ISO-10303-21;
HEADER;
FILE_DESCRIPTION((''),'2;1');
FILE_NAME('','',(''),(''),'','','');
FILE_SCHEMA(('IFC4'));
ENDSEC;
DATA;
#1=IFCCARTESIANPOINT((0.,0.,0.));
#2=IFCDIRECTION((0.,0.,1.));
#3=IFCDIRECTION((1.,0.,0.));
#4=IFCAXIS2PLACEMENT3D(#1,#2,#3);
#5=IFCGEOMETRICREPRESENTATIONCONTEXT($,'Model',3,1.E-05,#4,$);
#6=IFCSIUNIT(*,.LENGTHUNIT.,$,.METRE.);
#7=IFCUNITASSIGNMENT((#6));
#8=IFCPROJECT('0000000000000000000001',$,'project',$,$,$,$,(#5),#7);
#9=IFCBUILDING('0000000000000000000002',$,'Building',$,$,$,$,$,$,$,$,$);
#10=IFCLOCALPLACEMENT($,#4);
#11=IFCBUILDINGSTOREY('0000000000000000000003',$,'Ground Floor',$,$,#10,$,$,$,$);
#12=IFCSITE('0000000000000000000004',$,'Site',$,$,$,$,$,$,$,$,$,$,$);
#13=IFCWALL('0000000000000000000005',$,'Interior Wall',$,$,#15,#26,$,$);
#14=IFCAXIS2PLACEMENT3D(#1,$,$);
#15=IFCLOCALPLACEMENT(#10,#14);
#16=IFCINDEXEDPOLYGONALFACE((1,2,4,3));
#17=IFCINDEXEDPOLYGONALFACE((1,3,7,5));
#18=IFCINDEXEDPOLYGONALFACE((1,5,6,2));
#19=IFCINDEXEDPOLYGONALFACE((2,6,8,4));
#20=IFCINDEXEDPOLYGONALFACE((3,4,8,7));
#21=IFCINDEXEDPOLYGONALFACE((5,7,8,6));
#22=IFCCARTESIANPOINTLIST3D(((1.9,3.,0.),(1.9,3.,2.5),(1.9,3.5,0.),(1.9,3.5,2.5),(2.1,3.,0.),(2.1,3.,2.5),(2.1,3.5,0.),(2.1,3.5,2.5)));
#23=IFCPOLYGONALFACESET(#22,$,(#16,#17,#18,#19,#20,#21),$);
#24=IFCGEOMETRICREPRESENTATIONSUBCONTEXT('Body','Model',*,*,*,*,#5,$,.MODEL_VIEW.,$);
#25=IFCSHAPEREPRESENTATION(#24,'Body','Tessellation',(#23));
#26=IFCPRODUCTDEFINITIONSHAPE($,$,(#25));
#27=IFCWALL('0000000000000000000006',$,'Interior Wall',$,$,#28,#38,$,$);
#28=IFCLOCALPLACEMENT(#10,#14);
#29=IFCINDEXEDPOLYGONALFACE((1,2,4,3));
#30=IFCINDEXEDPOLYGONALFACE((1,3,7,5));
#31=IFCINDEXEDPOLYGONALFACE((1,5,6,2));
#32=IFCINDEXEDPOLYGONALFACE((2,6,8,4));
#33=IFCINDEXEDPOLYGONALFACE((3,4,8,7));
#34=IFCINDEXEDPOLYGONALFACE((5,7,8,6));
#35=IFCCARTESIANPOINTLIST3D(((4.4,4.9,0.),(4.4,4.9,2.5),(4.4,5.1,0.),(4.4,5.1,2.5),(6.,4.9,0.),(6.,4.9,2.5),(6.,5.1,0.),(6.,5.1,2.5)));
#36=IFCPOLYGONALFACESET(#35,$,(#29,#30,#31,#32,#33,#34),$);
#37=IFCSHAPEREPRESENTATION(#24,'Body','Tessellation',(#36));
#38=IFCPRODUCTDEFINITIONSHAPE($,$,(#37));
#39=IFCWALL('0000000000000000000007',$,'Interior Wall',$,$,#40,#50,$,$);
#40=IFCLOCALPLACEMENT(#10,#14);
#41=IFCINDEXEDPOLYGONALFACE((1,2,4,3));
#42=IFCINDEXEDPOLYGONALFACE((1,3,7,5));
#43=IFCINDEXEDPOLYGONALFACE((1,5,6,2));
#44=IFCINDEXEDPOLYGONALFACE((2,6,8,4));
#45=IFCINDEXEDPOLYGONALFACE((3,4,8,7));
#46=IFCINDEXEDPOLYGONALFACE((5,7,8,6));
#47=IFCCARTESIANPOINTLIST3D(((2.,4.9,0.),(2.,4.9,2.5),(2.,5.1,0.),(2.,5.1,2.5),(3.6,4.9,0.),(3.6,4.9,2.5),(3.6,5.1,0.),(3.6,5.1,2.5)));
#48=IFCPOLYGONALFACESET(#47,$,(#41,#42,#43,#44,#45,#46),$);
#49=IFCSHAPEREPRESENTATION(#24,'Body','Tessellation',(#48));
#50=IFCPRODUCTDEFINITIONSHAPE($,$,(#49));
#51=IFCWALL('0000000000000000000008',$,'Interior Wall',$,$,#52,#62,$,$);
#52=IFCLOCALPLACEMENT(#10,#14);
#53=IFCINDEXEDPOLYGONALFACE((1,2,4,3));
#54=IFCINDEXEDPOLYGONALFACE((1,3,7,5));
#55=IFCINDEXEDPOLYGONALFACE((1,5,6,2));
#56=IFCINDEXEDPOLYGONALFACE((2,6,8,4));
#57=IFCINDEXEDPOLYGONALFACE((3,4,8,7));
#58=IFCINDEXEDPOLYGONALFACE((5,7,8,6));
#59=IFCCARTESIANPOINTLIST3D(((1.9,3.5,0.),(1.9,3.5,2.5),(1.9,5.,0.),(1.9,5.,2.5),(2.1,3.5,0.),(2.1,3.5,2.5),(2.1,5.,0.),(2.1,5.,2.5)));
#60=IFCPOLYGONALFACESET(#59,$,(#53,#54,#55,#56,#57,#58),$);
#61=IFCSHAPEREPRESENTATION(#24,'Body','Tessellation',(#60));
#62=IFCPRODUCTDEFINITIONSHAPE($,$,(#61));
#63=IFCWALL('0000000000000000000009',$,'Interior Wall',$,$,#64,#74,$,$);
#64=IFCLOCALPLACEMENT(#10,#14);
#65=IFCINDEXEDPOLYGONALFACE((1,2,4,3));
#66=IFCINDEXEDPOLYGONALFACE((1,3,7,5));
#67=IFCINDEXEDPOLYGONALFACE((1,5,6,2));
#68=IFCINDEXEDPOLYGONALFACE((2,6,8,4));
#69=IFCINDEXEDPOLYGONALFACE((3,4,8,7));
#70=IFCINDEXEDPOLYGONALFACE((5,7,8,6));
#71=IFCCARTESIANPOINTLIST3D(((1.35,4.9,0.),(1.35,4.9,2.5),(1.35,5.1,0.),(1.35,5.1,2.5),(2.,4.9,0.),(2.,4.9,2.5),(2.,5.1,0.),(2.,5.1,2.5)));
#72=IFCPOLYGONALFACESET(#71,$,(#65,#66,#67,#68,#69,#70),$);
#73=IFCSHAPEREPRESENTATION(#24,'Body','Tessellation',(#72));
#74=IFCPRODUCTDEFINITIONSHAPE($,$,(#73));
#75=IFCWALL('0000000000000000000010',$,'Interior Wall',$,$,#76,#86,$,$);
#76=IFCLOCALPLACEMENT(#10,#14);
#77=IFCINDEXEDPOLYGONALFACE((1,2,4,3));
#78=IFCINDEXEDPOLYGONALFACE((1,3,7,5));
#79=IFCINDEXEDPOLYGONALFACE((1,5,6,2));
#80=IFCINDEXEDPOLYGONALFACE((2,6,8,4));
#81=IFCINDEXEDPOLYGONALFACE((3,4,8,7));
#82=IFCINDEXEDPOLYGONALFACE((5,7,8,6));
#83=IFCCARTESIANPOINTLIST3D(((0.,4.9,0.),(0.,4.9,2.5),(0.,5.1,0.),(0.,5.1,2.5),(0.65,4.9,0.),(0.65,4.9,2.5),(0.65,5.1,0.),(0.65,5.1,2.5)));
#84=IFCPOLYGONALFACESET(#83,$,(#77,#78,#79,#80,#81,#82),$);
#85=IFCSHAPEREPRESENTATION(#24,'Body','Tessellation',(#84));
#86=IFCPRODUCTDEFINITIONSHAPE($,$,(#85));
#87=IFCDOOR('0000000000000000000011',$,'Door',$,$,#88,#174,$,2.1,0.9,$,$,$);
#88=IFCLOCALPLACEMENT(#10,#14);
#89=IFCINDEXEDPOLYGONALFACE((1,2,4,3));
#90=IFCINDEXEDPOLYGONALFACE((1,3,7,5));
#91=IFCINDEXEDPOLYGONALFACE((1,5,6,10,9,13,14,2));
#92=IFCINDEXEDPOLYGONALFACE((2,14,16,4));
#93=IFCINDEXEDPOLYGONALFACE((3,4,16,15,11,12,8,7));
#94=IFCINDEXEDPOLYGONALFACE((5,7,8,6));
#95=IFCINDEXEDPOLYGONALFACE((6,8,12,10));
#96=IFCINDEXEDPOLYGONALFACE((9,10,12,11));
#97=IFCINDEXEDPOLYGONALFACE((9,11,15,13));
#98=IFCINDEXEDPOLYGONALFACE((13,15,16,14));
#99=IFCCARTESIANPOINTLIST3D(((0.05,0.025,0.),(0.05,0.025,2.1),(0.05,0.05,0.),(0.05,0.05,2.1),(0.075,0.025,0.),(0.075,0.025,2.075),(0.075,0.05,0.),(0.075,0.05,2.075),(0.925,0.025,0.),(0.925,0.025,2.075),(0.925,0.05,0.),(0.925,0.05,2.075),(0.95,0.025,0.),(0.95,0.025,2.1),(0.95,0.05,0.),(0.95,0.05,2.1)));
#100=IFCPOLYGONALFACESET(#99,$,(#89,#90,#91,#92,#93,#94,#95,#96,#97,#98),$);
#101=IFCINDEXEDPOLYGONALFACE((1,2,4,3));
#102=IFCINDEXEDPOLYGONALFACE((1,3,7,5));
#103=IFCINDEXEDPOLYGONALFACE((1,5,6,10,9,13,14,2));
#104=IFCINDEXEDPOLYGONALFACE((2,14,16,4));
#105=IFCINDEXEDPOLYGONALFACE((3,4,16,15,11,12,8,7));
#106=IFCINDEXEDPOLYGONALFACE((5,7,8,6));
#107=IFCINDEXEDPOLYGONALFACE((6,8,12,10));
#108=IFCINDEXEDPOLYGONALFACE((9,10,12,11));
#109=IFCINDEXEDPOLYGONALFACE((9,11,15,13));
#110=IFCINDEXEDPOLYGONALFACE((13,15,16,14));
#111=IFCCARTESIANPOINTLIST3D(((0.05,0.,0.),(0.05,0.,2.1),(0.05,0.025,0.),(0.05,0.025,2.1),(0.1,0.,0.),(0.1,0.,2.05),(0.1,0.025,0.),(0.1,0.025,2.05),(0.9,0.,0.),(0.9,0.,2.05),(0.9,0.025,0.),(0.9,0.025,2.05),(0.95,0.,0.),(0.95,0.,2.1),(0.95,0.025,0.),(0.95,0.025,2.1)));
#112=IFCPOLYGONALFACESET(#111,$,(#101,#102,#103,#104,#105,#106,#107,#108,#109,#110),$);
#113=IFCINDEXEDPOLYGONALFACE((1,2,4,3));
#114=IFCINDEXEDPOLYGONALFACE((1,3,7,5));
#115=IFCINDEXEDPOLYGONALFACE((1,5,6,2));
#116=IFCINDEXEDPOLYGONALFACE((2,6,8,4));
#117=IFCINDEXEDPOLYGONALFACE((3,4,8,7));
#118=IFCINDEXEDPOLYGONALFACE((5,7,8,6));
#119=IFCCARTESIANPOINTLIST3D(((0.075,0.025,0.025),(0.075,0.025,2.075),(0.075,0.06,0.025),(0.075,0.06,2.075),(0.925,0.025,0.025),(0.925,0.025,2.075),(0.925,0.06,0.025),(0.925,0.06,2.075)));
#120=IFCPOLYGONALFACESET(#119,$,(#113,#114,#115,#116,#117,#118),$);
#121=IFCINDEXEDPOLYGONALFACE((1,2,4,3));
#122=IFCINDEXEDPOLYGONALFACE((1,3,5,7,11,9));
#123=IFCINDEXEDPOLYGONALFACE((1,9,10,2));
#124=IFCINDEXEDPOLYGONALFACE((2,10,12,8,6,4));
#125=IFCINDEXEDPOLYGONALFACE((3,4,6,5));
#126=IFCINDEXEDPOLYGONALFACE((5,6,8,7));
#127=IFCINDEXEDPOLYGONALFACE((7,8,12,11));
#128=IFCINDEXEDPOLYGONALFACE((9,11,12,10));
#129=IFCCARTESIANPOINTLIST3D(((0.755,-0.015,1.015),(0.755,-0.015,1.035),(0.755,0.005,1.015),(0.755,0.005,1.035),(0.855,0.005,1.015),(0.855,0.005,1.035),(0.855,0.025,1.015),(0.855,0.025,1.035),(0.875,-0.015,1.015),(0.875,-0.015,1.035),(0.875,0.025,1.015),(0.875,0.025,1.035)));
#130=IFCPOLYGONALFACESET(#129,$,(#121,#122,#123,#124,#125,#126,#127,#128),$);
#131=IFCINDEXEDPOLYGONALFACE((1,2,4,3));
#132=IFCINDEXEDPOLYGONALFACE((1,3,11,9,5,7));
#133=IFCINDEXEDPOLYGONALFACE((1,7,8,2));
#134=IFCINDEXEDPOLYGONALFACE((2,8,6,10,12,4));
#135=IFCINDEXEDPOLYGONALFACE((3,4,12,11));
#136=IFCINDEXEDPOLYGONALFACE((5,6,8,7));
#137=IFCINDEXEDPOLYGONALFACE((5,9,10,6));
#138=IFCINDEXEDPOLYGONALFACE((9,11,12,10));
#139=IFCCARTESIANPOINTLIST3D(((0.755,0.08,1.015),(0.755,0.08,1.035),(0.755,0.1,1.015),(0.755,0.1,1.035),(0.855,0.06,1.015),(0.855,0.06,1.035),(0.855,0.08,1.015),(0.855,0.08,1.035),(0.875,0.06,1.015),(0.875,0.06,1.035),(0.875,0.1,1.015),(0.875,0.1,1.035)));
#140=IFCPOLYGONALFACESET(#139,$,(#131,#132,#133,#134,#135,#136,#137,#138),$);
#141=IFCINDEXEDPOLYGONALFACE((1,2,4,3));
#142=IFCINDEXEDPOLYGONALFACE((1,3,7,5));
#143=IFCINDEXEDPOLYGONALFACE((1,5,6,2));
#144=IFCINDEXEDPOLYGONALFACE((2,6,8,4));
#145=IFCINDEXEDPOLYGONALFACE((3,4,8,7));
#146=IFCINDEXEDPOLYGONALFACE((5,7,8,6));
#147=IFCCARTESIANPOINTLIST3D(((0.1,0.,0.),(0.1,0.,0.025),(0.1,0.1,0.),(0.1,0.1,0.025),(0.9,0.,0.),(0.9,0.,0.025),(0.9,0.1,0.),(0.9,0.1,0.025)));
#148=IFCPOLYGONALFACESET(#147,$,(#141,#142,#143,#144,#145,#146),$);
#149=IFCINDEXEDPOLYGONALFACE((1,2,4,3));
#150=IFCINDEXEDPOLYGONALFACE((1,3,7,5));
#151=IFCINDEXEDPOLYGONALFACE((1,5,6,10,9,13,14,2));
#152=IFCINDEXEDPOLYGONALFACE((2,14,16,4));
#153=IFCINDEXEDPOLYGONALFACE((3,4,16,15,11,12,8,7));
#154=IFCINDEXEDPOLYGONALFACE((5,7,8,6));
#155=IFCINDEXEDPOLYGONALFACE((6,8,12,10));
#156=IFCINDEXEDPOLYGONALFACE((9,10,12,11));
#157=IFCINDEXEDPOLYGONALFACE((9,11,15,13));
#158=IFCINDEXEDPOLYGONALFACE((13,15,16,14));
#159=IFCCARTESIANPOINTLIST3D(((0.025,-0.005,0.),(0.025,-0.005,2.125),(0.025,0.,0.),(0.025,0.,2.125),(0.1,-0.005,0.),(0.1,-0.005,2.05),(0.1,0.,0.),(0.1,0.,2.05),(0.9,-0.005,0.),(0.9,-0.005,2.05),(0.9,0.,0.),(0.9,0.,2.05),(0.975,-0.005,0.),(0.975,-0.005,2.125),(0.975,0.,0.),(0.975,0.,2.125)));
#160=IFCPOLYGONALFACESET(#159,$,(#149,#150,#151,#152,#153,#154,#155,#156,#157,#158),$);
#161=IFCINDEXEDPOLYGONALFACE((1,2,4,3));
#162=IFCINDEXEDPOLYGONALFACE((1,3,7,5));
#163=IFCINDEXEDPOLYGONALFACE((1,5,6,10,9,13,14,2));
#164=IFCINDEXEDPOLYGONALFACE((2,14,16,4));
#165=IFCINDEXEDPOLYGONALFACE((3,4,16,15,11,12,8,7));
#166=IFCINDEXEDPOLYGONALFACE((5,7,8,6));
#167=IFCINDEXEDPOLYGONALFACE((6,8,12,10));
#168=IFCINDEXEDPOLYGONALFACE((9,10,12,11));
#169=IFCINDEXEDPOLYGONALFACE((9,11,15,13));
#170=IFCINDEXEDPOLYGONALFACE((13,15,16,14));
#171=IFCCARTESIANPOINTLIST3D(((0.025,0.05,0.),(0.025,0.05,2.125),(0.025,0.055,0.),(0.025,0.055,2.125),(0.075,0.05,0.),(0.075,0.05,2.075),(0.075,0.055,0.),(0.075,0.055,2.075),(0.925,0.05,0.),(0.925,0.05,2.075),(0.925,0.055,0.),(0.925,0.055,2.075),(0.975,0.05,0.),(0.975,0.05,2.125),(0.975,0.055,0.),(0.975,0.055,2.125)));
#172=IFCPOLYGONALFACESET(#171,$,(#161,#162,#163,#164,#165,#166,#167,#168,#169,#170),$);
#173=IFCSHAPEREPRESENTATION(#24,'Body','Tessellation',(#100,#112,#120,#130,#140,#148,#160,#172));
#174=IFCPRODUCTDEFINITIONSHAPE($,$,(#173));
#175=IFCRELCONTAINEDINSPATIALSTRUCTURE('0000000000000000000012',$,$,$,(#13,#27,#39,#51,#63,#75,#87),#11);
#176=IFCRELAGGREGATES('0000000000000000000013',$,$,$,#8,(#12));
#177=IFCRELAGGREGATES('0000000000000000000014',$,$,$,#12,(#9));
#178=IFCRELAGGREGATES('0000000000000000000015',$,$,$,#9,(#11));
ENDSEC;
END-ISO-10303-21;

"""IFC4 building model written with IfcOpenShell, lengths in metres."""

from ifc_helpers import new_model, si_unit, frame, origin_with_axes, place, context, subcontext, project, spatial, line, indexed_curve, outline, extrude, element, save


model = new_model("IFC4")

# Units and contexts
model_context = context("Model", 3, precision=1e-05, world=origin_with_axes())
body_context = subcontext(model_context, "Body", "Model", "MODEL_VIEW")
ifc_project = project(units=[si_unit("LENGTHUNIT", "METRE")], contexts=[model_context])

# Site, building, storey
site = spatial("IfcSite", under=ifc_project, Name="Site")
building = spatial("IfcBuilding", under=site, Name="Building")
storey_placement = place(None, origin_with_axes())
storey = spatial("IfcBuildingStorey", under=building, at=storey_placement, Name="Ground Floor")

# Walls
wall_1_placement = place(storey_placement, frame((2.0, 3.5, 0.0), z_axis=(0.0, 0.0, 1.0), x_axis=(0.0, -1.0, 0.0)))
element("IfcWall", 1, at=wall_1_placement, inside=storey, Name="Interior Wall", context=body_context, shape_type="SweptSolid", body=[
    extrude(outline(indexed_curve([(0.0, 0.0), (0.0, 0.2), (0.5, 0.2), (0.5, 0.0), (0.0, 0.0)], self_intersect=False)), frame((0.0, -0.1, 0.0), z_axis=(0.0, 0.0, 1.0), x_axis=(1.0, 0.0, 0.0)), (0.0, 0.0, 1.0), 2.5),
])
wall_2_placement = place(storey_placement, frame((6.0, 5.0, 0.0), z_axis=(0.0, 0.0, 1.0), x_axis=(-1.0, 0.0, 0.0)))
element("IfcWall", 2, at=wall_2_placement, inside=storey, Name="Interior Wall", context=body_context, shape_type="SweptSolid", body=[
    extrude(outline(indexed_curve([(0.0, 0.0), (0.0, 0.2), (1.6, 0.2), (1.6, 0.0), (0.0, 0.0)], self_intersect=False)), frame((0.0, -0.1, 0.0), z_axis=(0.0, 0.0, 1.0), x_axis=(1.0, 0.0, 0.0)), (0.0, 0.0, 1.0), 2.5),
])
wall_3_placement = place(storey_placement, frame((3.6, 5.0, 0.0), z_axis=(0.0, 0.0, 1.0), x_axis=(-1.0, 0.0, 0.0)))
element("IfcWall", 3, at=wall_3_placement, inside=storey, Name="Interior Wall", context=body_context, shape_type="SweptSolid", body=[
    extrude(outline(indexed_curve([(0.0, 0.0), (0.0, 0.2), (1.6, 0.2), (1.6, 0.0), (0.0, 0.0)], self_intersect=False)), frame((0.0, -0.1, 0.0), z_axis=(0.0, 0.0, 1.0), x_axis=(1.0, 0.0, 0.0)), (0.0, 0.0, 1.0), 2.5),
])
wall_4_placement = place(storey_placement, frame((2.0, 5.0, 0.0), z_axis=(0.0, 0.0, 1.0), x_axis=(0.0, -1.0, 0.0)))
element("IfcWall", 4, at=wall_4_placement, inside=storey, Name="Interior Wall", context=body_context, shape_type="SweptSolid", body=[
    extrude(outline(indexed_curve([(0.0, 0.0), (0.0, 0.2), (1.5, 0.2), (1.5, 0.0), (0.0, 0.0)], self_intersect=False)), frame((0.0, -0.1, 0.0), z_axis=(0.0, 0.0, 1.0), x_axis=(1.0, 0.0, 0.0)), (0.0, 0.0, 1.0), 2.5),
])
for number, where, z_axis, x_axis, name in (
    (5, (2.0, 5.0, 0.0), (0.0, 0.0, 1.0), (-1.0, 0.0, 0.0), "Interior Wall"),
    (6, (0.65, 5.0, 0.0), (0.0, 0.0, 1.0), (-1.0, 0.0, 0.0), "Interior Wall"),
):
    element("IfcWall", number, at=place(storey_placement, frame(where, z_axis=z_axis, x_axis=x_axis)), inside=storey, Name=name, context=body_context, shape_type="SweptSolid", body=[
        extrude(outline(indexed_curve([(0.0, 0.0), (0.0, 0.2), (0.65, 0.2), (0.65, 0.0), (0.0, 0.0)], self_intersect=False)), frame((0.0, -0.1, 0.0), z_axis=(0.0, 0.0, 1.0), x_axis=(1.0, 0.0, 0.0)), (0.0, 0.0, 1.0), 2.5),
    ])

# Door
door_1_placement = place(storey_placement, frame((0.05, 0.0, 0.0), z_axis=(0.0, 0.0, 1.0), x_axis=(1.0, 0.0, 0.0)))
element("IfcDoor", 7, at=door_1_placement, inside=storey, Name="Door", OverallHeight=2.1, OverallWidth=0.9, context=body_context, shape_type="SweptSolid", body=[
    extrude(outline(indexed_curve([(0.0, 0.0), (0.0, 2.1), (0.9, 2.1), (0.9, 0.0), (0.875, 0.0), (0.875, 2.075), (0.025, 2.075), (0.025, 0.0)], segments=[line(1, 2, 3, 4, 5, 6, 7, 8, 1)])), frame((0.0, 0.025, 0.0), z_axis=(0.0, -1.0, 0.0), x_axis=(1.0, 0.0, 0.0)), (0.0, 0.0, -1.0), 0.025),
    extrude(outline(indexed_curve([(0.0, 0.0), (0.0, 2.1), (0.9, 2.1), (0.9, 0.0), (0.85, 0.0), (0.85, 2.05), (0.05, 2.05), (0.05, 0.0)], segments=[line(1, 2, 3, 4, 5, 6, 7, 8, 1)])), frame((0.0, 0.0, 0.0), z_axis=(0.0, -1.0, 0.0), x_axis=(1.0, 0.0, 0.0)), (0.0, 0.0, -1.0), 0.025),
    extrude(outline(indexed_curve([(0.0, 0.0), (0.85, 0.0), (0.85, 0.035), (0.0, 0.035)], segments=[line(1, 2, 3, 4, 1)])), frame((0.025, 0.025, 0.025), z_axis=(0.0, 0.0, 1.0), x_axis=(1.0, 0.0, 0.0)), (0.0, 0.0, 1.0), 2.05),
    extrude(outline(indexed_curve([(0.0, 0.0), (0.0, -0.04), (-0.12, -0.04), (-0.12, -0.02), (-0.02, -0.02), (-0.02, 0.0)], segments=[line(1, 2, 3, 4, 5, 6, 1)])), frame((0.825, 0.025, 1.015), z_axis=(0.0, 0.0, 1.0), x_axis=(1.0, 0.0, 0.0)), (0.0, 0.0, 1.0), 0.02),
    extrude(outline(indexed_curve([(0.0, 0.0), (0.0, 0.04), (-0.12, 0.04), (-0.12, 0.02), (-0.02, 0.02), (-0.02, 0.0)], segments=[line(1, 2, 3, 4, 5, 6, 1)])), frame((0.825, 0.06, 1.015), z_axis=(0.0, 0.0, 1.0), x_axis=(1.0, 0.0, 0.0)), (0.0, 0.0, 1.0), 0.02),
    extrude(outline(indexed_curve([(0.0, 0.0), (0.8, 0.0), (0.8, 0.1), (0.0, 0.1)], segments=[line(1, 2, 3, 4, 1)])), frame((0.05, 0.0, 0.0), z_axis=(0.0, 0.0, 1.0), x_axis=(1.0, 0.0, 0.0)), (0.0, 0.0, 1.0), 0.025),
    extrude(outline(indexed_curve([(0.0, 0.0), (0.0, 2.125), (0.95, 2.125), (0.95, 0.0), (0.875, 0.0), (0.875, 2.05), (0.075, 2.05), (0.075, 0.0)], segments=[line(1, 2, 3, 4, 5, 6, 7, 8, 1)])), frame((-0.025, -0.005, 0.0), z_axis=(0.0, -1.0, 0.0), x_axis=(1.0, 0.0, 0.0)), (0.0, 0.0, -1.0), 0.005),
    extrude(outline(indexed_curve([(0.0, 0.0), (0.0, 2.125), (0.95, 2.125), (0.95, 0.0), (0.9, 0.0), (0.9, 2.075), (0.05, 2.075), (0.05, 0.0)], segments=[line(1, 2, 3, 4, 5, 6, 7, 8, 1)])), frame((-0.025, 0.05, 0.0), z_axis=(0.0, -1.0, 0.0), x_axis=(1.0, 0.0, 0.0)), (0.0, 0.0, -1.0), 0.005),
])

save(model, "model.ifc")
